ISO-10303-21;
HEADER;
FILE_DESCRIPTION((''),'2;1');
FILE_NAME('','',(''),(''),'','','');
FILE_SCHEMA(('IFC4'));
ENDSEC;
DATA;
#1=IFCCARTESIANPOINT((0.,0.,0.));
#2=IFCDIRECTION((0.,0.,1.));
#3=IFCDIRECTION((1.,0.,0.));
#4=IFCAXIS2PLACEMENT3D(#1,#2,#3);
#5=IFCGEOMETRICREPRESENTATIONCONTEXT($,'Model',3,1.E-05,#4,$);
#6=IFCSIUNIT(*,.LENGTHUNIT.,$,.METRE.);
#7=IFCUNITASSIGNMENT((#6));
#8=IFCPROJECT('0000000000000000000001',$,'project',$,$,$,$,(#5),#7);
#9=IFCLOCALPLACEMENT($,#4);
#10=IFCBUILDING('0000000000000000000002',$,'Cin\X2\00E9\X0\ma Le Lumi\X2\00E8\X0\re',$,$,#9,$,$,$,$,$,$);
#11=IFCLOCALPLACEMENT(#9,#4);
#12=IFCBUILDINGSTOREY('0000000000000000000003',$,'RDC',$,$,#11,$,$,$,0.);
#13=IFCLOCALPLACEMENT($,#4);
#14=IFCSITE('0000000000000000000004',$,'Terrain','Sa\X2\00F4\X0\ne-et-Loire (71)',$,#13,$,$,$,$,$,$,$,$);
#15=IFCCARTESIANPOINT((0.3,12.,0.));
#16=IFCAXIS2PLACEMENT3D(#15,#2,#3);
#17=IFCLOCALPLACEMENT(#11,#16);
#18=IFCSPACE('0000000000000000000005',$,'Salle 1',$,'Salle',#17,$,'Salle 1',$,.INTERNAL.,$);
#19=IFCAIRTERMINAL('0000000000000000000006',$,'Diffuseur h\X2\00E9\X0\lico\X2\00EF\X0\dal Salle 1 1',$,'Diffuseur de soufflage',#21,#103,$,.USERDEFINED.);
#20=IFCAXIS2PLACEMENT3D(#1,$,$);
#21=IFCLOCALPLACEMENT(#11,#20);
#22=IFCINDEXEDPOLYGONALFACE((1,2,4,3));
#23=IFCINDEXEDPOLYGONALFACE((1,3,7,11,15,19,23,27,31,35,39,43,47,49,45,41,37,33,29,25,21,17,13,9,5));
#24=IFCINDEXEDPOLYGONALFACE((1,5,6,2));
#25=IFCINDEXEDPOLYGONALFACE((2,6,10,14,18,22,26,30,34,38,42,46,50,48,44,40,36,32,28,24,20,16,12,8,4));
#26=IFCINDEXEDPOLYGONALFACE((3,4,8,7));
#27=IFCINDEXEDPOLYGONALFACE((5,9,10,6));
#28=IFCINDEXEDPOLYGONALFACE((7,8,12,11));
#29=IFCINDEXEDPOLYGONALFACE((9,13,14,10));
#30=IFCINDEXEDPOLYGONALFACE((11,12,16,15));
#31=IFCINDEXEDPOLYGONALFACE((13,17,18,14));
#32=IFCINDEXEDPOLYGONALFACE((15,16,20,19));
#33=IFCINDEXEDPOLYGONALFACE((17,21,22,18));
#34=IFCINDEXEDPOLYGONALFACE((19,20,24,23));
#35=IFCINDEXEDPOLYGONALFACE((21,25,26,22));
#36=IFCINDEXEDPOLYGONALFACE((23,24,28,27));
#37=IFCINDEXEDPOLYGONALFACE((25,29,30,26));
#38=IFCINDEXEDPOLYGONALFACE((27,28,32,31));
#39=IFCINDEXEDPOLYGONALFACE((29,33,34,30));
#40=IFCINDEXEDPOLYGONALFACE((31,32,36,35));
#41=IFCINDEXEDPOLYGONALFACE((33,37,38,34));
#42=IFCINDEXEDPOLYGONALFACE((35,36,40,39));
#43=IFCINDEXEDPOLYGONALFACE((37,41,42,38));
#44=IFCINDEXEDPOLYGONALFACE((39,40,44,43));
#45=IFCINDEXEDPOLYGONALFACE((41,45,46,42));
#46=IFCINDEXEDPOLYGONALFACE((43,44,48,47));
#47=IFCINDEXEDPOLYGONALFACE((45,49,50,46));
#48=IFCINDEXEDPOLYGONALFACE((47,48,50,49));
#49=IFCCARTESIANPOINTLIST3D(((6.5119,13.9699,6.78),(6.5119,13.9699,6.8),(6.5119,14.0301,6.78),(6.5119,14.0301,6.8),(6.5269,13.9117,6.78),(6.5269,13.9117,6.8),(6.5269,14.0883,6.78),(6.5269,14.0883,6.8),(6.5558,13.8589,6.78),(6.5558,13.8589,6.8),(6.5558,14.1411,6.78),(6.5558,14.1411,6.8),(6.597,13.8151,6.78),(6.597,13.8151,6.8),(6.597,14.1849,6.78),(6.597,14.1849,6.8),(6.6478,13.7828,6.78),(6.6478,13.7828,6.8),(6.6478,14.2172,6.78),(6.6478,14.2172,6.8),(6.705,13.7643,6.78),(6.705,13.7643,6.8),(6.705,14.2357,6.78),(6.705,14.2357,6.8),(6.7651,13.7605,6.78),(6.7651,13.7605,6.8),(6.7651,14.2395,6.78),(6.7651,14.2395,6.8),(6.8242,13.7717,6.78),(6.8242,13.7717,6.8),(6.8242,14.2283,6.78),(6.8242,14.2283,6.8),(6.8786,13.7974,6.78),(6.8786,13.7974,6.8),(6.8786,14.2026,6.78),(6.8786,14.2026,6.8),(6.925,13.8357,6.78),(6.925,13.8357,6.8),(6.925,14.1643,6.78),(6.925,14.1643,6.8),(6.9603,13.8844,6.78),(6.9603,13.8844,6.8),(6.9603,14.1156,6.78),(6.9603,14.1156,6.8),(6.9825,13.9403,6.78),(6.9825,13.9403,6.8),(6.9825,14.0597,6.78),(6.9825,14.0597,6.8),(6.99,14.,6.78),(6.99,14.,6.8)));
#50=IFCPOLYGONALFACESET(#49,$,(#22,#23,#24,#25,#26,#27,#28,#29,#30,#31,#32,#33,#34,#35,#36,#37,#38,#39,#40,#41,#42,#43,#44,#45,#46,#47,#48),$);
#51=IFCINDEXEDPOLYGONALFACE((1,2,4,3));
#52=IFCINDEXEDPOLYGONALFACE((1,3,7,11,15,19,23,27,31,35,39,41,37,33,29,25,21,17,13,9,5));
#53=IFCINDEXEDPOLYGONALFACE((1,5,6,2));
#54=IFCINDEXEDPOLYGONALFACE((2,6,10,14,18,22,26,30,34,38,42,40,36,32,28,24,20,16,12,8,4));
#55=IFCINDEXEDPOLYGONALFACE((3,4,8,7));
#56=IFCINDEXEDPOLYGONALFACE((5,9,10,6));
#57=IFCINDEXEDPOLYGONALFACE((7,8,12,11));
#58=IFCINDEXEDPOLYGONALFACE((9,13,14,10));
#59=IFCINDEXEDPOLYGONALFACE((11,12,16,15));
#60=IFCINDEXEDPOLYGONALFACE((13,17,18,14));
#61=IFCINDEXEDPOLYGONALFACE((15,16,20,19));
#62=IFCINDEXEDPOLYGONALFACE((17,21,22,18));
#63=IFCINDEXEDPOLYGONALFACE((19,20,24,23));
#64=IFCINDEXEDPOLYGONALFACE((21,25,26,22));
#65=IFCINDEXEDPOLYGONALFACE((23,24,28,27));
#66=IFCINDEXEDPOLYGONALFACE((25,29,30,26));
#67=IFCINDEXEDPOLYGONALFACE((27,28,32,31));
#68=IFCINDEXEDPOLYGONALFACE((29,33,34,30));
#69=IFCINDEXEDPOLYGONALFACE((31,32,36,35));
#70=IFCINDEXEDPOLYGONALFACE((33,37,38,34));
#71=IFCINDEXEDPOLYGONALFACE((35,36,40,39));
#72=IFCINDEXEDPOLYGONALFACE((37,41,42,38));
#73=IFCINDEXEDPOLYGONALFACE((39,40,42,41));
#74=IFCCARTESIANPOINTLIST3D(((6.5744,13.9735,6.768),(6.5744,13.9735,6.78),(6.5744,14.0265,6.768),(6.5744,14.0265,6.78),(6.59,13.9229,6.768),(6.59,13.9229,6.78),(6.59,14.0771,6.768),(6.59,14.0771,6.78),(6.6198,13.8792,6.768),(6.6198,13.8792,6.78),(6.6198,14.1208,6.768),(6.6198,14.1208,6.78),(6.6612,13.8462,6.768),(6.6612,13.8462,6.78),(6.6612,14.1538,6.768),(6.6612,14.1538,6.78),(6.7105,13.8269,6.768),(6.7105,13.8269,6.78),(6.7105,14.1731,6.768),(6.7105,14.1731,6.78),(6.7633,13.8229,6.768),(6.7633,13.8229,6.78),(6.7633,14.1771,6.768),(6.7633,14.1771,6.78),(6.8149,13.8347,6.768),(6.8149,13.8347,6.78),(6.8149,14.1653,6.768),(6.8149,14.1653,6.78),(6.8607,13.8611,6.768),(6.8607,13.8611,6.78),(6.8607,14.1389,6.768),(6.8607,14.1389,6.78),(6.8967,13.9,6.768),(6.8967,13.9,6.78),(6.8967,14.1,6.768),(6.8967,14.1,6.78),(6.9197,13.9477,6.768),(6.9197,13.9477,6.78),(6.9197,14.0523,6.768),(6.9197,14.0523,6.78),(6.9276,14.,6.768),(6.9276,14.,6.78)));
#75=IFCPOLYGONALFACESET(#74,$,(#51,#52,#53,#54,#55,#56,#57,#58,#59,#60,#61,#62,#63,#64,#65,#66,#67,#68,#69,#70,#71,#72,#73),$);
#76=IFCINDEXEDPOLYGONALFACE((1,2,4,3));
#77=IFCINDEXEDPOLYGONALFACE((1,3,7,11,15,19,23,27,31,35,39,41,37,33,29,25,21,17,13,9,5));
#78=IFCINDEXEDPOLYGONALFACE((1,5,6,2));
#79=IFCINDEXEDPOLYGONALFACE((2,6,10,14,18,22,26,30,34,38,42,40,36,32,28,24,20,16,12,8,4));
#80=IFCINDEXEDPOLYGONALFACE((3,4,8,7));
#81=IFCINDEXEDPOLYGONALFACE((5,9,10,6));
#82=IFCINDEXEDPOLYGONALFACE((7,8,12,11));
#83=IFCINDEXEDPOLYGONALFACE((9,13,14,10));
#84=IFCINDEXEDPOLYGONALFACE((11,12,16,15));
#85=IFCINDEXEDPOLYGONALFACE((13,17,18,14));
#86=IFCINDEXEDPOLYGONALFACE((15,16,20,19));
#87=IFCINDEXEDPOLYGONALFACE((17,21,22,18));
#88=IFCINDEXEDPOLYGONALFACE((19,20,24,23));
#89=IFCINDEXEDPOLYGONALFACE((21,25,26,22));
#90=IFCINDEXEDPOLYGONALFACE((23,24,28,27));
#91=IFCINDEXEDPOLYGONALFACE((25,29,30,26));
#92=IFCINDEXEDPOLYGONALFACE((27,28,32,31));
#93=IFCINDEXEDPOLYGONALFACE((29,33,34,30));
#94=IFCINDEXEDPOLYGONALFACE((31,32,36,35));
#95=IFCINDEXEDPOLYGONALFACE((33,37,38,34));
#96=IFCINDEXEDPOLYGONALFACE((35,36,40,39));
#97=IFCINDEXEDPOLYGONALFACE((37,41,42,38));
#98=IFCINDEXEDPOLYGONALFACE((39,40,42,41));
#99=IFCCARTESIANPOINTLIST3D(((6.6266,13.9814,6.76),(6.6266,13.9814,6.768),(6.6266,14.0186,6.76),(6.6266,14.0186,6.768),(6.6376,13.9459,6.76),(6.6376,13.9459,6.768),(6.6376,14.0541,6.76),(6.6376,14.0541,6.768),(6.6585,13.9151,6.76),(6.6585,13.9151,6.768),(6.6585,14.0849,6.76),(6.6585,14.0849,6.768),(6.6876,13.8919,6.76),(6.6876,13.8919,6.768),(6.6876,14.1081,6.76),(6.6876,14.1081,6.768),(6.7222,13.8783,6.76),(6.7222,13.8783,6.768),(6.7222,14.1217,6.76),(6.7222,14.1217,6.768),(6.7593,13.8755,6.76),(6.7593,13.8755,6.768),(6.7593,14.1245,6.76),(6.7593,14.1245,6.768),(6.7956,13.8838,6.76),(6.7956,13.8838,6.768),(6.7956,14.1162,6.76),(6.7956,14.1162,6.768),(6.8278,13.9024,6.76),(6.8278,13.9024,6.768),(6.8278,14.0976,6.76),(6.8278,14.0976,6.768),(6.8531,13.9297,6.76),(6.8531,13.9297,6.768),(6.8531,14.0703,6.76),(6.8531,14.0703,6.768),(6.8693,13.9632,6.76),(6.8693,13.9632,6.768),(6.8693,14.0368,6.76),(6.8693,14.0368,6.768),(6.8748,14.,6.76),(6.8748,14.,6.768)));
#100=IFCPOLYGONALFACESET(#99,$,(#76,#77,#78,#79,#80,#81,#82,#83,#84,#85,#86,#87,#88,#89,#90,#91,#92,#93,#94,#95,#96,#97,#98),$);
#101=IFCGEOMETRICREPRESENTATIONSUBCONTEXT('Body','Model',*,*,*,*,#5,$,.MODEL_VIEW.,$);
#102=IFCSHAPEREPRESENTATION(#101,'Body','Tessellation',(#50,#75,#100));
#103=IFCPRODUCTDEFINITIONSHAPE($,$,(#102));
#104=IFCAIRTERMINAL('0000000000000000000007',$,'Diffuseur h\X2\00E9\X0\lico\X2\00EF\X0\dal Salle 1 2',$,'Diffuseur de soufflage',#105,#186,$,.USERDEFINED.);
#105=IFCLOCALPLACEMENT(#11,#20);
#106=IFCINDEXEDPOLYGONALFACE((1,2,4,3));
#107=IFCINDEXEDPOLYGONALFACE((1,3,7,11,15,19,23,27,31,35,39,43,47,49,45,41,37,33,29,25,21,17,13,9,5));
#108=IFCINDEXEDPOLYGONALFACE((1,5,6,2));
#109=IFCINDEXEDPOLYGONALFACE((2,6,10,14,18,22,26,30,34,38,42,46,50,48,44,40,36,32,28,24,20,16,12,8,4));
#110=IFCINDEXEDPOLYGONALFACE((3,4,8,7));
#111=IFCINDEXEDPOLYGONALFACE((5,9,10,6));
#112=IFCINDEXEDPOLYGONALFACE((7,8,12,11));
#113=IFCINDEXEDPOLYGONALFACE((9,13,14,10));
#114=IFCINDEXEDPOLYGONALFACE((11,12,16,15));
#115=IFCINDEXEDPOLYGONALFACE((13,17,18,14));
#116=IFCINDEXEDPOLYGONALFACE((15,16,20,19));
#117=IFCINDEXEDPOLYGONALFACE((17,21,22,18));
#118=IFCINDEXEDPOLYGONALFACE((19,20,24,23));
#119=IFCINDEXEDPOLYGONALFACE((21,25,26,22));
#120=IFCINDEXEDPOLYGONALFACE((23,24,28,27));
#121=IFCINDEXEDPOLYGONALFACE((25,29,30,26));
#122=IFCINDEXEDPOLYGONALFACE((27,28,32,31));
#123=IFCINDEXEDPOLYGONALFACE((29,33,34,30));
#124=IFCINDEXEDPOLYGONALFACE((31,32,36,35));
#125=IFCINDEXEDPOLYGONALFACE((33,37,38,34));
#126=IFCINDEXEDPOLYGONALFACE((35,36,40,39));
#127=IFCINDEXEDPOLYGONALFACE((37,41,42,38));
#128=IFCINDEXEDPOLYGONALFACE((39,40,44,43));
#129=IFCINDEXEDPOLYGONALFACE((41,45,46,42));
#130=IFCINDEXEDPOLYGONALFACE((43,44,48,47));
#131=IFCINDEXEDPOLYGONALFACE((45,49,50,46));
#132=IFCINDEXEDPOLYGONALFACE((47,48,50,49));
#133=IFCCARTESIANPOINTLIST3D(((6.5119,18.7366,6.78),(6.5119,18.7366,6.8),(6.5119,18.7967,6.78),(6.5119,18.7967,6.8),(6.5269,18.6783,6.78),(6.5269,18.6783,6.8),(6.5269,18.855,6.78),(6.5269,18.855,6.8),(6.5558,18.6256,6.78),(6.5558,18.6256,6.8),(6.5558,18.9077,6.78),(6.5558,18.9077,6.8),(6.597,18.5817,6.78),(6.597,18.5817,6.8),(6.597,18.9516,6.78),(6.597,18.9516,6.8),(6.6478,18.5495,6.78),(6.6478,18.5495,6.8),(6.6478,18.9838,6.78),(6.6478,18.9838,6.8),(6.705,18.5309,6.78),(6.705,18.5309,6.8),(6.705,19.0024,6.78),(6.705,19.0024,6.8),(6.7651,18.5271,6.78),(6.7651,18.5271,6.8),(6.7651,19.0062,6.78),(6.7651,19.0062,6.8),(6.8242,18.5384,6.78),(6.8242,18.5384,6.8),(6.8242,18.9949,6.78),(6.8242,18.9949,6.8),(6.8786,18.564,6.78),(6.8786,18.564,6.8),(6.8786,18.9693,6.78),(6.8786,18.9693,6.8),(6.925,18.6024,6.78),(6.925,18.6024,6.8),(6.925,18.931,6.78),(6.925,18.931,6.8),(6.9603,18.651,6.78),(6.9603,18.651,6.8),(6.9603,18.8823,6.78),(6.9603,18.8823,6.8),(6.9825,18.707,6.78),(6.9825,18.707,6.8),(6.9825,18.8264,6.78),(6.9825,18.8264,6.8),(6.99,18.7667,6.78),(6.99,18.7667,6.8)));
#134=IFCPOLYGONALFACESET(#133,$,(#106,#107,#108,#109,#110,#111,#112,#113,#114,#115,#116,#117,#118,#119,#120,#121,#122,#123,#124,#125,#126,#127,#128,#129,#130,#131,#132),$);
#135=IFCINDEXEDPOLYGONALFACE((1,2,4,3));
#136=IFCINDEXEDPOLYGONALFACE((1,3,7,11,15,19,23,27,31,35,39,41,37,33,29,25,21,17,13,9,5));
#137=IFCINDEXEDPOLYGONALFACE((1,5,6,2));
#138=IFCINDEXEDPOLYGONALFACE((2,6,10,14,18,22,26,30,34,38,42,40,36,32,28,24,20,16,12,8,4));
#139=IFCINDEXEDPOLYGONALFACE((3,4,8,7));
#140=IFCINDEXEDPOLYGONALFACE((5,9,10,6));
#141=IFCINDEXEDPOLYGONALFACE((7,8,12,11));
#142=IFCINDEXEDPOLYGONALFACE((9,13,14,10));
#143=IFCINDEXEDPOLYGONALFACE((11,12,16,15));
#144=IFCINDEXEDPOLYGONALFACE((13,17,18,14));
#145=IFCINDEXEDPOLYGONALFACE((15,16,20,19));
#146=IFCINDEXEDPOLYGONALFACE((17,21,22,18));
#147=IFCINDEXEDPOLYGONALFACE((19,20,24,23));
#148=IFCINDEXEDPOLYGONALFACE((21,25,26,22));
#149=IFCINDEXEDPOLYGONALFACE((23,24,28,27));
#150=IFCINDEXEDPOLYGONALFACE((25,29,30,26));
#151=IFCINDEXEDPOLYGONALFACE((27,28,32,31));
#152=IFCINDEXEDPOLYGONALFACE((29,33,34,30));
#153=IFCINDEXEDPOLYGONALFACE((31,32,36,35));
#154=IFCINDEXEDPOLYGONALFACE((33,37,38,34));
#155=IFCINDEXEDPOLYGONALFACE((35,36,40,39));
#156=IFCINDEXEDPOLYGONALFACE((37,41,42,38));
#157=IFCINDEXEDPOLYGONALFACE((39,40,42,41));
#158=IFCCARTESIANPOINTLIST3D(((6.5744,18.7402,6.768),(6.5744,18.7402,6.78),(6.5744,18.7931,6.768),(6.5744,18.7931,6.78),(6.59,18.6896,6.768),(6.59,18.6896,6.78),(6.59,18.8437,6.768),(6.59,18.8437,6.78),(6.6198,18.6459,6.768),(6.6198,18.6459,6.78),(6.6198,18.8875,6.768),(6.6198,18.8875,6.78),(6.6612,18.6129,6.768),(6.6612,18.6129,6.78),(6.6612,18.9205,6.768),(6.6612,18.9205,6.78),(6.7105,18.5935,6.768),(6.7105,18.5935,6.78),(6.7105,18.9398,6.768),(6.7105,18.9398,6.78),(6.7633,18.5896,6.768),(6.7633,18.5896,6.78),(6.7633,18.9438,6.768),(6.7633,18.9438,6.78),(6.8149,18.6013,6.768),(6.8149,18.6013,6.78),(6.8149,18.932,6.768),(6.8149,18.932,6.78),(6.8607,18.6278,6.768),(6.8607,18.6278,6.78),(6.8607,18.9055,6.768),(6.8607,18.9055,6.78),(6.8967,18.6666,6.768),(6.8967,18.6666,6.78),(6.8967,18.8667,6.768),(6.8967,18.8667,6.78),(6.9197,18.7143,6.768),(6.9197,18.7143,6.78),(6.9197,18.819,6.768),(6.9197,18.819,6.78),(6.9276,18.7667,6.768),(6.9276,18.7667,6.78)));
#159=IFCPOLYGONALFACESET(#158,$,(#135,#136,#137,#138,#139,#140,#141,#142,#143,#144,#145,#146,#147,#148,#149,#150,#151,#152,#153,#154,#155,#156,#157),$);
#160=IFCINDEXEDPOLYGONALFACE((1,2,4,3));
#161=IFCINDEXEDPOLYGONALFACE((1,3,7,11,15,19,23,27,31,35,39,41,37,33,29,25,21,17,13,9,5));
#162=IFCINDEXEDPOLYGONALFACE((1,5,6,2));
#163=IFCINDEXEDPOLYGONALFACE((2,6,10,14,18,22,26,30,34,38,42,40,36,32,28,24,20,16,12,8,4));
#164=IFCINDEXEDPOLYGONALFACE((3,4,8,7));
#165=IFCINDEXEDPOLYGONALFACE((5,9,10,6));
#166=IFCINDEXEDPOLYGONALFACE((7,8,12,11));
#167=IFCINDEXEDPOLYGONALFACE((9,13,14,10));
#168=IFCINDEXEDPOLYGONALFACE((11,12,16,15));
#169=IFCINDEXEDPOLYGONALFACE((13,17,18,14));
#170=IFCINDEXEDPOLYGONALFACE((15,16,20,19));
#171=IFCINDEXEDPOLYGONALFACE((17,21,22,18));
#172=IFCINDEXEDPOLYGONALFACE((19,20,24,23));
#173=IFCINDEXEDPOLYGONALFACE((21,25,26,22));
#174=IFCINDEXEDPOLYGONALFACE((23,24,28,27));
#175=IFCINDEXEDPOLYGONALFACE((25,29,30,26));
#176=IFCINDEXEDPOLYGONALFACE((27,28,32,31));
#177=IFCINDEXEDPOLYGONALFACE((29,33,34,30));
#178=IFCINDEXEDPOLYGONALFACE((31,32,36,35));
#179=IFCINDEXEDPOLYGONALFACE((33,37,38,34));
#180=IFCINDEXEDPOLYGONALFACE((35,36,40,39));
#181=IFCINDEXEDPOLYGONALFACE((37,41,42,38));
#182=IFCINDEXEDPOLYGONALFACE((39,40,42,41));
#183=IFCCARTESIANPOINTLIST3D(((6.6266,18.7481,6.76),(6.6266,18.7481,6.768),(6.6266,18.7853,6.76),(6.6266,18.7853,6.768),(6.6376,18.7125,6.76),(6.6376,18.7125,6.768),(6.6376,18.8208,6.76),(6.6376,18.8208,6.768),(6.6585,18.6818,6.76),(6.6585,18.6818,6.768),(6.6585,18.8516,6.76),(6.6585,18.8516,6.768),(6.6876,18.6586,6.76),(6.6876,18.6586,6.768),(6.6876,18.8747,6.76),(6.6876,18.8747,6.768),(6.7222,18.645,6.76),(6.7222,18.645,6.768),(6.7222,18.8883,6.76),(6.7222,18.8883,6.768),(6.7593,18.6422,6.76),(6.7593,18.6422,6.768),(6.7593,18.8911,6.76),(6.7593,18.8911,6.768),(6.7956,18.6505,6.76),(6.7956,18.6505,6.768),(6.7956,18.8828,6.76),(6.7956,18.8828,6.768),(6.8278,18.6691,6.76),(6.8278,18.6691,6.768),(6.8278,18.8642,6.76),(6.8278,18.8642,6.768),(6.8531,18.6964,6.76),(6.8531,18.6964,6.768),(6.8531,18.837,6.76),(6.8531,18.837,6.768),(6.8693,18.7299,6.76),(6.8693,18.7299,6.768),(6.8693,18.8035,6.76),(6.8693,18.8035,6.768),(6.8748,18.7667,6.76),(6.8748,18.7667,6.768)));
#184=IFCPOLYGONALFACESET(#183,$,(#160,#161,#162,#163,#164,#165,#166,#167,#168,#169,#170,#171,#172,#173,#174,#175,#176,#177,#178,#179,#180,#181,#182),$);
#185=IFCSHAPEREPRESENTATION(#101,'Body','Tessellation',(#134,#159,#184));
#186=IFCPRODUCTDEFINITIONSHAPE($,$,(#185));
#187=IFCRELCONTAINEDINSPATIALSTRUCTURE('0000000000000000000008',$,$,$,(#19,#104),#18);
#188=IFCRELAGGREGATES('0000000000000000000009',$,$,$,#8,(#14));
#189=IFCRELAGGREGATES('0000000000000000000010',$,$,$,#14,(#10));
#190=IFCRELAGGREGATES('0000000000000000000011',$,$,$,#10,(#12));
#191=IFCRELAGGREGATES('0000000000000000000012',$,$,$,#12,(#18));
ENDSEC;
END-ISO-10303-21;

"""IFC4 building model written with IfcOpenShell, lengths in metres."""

from ifc_helpers import new_model, si_unit, frame, origin_with_axes, place, context, subcontext, project, spatial, circle, extrude, element, save


model = new_model("IFC4")

# Units and contexts
model_context = context("Model", 3, precision=1e-05, world=origin_with_axes())
body_context = subcontext(model_context, "Body", "Model", "MODEL_VIEW")
ifc_project = project(units=[si_unit("LENGTHUNIT", "METRE")], contexts=[model_context])

# Site, building, storey
site_placement = place(None, origin_with_axes())
site = spatial("IfcSite", under=ifc_project, at=site_placement, Name="Terrain", Description="Saône-et-Loire (71)")
building_placement = place(None, origin_with_axes())
building = spatial("IfcBuilding", under=site, at=building_placement, Name="Cinéma Le Lumière")
storey_placement = place(building_placement, origin_with_axes())
storey = spatial("IfcBuildingStorey", under=building, at=storey_placement, Name="RDC", Elevation=0.0)

# Shared definitions
space_1_placement = place(storey_placement, frame((0.3, 12.0, 0.0), z_axis=(0.0, 0.0, 1.0), x_axis=(1.0, 0.0, 0.0)))
space_1 = spatial("IfcSpace", under=storey, at=space_1_placement, Name="Salle 1", ObjectType="Salle", LongName="Salle 1", PredefinedType="INTERNAL")

# Air terminals
for number, where, z_axis, x_axis, name in (
    (1, (6.45, 2.0, 6.76), (0.0, 0.0, 1.0), (1.0, 0.0, 0.0), "Diffuseur hélicoïdal Salle 1 1"),
    (2, (6.45, 6.7667, 6.76), (0.0, 0.0, 1.0), (1.0, 0.0, 0.0), "Diffuseur hélicoïdal Salle 1 2"),
):
    element("IfcAirTerminal", number, at=place(space_1_placement, frame(where, z_axis=z_axis, x_axis=x_axis)), inside=space_1, Name=name, ObjectType="Diffuseur de soufflage", PredefinedType="USERDEFINED", context=body_context, shape_type="SweptSolid", body=[
        extrude(circle(Radius=0.24), frame((0.0, 0.0, 0.02), z_axis=(0.0, 0.0, 1.0), x_axis=(1.0, 0.0, 0.0)), (0.0, 0.0, 1.0), 0.02),
        extrude(circle(Radius=0.1776), frame((0.0, 0.0, 0.008), z_axis=(0.0, 0.0, 1.0), x_axis=(1.0, 0.0, 0.0)), (0.0, 0.0, 1.0), 0.012),
        extrude(circle(Radius=0.1248), origin_with_axes(), (0.0, 0.0, 1.0), 0.008),
    ])

save(model, "model.ifc")
